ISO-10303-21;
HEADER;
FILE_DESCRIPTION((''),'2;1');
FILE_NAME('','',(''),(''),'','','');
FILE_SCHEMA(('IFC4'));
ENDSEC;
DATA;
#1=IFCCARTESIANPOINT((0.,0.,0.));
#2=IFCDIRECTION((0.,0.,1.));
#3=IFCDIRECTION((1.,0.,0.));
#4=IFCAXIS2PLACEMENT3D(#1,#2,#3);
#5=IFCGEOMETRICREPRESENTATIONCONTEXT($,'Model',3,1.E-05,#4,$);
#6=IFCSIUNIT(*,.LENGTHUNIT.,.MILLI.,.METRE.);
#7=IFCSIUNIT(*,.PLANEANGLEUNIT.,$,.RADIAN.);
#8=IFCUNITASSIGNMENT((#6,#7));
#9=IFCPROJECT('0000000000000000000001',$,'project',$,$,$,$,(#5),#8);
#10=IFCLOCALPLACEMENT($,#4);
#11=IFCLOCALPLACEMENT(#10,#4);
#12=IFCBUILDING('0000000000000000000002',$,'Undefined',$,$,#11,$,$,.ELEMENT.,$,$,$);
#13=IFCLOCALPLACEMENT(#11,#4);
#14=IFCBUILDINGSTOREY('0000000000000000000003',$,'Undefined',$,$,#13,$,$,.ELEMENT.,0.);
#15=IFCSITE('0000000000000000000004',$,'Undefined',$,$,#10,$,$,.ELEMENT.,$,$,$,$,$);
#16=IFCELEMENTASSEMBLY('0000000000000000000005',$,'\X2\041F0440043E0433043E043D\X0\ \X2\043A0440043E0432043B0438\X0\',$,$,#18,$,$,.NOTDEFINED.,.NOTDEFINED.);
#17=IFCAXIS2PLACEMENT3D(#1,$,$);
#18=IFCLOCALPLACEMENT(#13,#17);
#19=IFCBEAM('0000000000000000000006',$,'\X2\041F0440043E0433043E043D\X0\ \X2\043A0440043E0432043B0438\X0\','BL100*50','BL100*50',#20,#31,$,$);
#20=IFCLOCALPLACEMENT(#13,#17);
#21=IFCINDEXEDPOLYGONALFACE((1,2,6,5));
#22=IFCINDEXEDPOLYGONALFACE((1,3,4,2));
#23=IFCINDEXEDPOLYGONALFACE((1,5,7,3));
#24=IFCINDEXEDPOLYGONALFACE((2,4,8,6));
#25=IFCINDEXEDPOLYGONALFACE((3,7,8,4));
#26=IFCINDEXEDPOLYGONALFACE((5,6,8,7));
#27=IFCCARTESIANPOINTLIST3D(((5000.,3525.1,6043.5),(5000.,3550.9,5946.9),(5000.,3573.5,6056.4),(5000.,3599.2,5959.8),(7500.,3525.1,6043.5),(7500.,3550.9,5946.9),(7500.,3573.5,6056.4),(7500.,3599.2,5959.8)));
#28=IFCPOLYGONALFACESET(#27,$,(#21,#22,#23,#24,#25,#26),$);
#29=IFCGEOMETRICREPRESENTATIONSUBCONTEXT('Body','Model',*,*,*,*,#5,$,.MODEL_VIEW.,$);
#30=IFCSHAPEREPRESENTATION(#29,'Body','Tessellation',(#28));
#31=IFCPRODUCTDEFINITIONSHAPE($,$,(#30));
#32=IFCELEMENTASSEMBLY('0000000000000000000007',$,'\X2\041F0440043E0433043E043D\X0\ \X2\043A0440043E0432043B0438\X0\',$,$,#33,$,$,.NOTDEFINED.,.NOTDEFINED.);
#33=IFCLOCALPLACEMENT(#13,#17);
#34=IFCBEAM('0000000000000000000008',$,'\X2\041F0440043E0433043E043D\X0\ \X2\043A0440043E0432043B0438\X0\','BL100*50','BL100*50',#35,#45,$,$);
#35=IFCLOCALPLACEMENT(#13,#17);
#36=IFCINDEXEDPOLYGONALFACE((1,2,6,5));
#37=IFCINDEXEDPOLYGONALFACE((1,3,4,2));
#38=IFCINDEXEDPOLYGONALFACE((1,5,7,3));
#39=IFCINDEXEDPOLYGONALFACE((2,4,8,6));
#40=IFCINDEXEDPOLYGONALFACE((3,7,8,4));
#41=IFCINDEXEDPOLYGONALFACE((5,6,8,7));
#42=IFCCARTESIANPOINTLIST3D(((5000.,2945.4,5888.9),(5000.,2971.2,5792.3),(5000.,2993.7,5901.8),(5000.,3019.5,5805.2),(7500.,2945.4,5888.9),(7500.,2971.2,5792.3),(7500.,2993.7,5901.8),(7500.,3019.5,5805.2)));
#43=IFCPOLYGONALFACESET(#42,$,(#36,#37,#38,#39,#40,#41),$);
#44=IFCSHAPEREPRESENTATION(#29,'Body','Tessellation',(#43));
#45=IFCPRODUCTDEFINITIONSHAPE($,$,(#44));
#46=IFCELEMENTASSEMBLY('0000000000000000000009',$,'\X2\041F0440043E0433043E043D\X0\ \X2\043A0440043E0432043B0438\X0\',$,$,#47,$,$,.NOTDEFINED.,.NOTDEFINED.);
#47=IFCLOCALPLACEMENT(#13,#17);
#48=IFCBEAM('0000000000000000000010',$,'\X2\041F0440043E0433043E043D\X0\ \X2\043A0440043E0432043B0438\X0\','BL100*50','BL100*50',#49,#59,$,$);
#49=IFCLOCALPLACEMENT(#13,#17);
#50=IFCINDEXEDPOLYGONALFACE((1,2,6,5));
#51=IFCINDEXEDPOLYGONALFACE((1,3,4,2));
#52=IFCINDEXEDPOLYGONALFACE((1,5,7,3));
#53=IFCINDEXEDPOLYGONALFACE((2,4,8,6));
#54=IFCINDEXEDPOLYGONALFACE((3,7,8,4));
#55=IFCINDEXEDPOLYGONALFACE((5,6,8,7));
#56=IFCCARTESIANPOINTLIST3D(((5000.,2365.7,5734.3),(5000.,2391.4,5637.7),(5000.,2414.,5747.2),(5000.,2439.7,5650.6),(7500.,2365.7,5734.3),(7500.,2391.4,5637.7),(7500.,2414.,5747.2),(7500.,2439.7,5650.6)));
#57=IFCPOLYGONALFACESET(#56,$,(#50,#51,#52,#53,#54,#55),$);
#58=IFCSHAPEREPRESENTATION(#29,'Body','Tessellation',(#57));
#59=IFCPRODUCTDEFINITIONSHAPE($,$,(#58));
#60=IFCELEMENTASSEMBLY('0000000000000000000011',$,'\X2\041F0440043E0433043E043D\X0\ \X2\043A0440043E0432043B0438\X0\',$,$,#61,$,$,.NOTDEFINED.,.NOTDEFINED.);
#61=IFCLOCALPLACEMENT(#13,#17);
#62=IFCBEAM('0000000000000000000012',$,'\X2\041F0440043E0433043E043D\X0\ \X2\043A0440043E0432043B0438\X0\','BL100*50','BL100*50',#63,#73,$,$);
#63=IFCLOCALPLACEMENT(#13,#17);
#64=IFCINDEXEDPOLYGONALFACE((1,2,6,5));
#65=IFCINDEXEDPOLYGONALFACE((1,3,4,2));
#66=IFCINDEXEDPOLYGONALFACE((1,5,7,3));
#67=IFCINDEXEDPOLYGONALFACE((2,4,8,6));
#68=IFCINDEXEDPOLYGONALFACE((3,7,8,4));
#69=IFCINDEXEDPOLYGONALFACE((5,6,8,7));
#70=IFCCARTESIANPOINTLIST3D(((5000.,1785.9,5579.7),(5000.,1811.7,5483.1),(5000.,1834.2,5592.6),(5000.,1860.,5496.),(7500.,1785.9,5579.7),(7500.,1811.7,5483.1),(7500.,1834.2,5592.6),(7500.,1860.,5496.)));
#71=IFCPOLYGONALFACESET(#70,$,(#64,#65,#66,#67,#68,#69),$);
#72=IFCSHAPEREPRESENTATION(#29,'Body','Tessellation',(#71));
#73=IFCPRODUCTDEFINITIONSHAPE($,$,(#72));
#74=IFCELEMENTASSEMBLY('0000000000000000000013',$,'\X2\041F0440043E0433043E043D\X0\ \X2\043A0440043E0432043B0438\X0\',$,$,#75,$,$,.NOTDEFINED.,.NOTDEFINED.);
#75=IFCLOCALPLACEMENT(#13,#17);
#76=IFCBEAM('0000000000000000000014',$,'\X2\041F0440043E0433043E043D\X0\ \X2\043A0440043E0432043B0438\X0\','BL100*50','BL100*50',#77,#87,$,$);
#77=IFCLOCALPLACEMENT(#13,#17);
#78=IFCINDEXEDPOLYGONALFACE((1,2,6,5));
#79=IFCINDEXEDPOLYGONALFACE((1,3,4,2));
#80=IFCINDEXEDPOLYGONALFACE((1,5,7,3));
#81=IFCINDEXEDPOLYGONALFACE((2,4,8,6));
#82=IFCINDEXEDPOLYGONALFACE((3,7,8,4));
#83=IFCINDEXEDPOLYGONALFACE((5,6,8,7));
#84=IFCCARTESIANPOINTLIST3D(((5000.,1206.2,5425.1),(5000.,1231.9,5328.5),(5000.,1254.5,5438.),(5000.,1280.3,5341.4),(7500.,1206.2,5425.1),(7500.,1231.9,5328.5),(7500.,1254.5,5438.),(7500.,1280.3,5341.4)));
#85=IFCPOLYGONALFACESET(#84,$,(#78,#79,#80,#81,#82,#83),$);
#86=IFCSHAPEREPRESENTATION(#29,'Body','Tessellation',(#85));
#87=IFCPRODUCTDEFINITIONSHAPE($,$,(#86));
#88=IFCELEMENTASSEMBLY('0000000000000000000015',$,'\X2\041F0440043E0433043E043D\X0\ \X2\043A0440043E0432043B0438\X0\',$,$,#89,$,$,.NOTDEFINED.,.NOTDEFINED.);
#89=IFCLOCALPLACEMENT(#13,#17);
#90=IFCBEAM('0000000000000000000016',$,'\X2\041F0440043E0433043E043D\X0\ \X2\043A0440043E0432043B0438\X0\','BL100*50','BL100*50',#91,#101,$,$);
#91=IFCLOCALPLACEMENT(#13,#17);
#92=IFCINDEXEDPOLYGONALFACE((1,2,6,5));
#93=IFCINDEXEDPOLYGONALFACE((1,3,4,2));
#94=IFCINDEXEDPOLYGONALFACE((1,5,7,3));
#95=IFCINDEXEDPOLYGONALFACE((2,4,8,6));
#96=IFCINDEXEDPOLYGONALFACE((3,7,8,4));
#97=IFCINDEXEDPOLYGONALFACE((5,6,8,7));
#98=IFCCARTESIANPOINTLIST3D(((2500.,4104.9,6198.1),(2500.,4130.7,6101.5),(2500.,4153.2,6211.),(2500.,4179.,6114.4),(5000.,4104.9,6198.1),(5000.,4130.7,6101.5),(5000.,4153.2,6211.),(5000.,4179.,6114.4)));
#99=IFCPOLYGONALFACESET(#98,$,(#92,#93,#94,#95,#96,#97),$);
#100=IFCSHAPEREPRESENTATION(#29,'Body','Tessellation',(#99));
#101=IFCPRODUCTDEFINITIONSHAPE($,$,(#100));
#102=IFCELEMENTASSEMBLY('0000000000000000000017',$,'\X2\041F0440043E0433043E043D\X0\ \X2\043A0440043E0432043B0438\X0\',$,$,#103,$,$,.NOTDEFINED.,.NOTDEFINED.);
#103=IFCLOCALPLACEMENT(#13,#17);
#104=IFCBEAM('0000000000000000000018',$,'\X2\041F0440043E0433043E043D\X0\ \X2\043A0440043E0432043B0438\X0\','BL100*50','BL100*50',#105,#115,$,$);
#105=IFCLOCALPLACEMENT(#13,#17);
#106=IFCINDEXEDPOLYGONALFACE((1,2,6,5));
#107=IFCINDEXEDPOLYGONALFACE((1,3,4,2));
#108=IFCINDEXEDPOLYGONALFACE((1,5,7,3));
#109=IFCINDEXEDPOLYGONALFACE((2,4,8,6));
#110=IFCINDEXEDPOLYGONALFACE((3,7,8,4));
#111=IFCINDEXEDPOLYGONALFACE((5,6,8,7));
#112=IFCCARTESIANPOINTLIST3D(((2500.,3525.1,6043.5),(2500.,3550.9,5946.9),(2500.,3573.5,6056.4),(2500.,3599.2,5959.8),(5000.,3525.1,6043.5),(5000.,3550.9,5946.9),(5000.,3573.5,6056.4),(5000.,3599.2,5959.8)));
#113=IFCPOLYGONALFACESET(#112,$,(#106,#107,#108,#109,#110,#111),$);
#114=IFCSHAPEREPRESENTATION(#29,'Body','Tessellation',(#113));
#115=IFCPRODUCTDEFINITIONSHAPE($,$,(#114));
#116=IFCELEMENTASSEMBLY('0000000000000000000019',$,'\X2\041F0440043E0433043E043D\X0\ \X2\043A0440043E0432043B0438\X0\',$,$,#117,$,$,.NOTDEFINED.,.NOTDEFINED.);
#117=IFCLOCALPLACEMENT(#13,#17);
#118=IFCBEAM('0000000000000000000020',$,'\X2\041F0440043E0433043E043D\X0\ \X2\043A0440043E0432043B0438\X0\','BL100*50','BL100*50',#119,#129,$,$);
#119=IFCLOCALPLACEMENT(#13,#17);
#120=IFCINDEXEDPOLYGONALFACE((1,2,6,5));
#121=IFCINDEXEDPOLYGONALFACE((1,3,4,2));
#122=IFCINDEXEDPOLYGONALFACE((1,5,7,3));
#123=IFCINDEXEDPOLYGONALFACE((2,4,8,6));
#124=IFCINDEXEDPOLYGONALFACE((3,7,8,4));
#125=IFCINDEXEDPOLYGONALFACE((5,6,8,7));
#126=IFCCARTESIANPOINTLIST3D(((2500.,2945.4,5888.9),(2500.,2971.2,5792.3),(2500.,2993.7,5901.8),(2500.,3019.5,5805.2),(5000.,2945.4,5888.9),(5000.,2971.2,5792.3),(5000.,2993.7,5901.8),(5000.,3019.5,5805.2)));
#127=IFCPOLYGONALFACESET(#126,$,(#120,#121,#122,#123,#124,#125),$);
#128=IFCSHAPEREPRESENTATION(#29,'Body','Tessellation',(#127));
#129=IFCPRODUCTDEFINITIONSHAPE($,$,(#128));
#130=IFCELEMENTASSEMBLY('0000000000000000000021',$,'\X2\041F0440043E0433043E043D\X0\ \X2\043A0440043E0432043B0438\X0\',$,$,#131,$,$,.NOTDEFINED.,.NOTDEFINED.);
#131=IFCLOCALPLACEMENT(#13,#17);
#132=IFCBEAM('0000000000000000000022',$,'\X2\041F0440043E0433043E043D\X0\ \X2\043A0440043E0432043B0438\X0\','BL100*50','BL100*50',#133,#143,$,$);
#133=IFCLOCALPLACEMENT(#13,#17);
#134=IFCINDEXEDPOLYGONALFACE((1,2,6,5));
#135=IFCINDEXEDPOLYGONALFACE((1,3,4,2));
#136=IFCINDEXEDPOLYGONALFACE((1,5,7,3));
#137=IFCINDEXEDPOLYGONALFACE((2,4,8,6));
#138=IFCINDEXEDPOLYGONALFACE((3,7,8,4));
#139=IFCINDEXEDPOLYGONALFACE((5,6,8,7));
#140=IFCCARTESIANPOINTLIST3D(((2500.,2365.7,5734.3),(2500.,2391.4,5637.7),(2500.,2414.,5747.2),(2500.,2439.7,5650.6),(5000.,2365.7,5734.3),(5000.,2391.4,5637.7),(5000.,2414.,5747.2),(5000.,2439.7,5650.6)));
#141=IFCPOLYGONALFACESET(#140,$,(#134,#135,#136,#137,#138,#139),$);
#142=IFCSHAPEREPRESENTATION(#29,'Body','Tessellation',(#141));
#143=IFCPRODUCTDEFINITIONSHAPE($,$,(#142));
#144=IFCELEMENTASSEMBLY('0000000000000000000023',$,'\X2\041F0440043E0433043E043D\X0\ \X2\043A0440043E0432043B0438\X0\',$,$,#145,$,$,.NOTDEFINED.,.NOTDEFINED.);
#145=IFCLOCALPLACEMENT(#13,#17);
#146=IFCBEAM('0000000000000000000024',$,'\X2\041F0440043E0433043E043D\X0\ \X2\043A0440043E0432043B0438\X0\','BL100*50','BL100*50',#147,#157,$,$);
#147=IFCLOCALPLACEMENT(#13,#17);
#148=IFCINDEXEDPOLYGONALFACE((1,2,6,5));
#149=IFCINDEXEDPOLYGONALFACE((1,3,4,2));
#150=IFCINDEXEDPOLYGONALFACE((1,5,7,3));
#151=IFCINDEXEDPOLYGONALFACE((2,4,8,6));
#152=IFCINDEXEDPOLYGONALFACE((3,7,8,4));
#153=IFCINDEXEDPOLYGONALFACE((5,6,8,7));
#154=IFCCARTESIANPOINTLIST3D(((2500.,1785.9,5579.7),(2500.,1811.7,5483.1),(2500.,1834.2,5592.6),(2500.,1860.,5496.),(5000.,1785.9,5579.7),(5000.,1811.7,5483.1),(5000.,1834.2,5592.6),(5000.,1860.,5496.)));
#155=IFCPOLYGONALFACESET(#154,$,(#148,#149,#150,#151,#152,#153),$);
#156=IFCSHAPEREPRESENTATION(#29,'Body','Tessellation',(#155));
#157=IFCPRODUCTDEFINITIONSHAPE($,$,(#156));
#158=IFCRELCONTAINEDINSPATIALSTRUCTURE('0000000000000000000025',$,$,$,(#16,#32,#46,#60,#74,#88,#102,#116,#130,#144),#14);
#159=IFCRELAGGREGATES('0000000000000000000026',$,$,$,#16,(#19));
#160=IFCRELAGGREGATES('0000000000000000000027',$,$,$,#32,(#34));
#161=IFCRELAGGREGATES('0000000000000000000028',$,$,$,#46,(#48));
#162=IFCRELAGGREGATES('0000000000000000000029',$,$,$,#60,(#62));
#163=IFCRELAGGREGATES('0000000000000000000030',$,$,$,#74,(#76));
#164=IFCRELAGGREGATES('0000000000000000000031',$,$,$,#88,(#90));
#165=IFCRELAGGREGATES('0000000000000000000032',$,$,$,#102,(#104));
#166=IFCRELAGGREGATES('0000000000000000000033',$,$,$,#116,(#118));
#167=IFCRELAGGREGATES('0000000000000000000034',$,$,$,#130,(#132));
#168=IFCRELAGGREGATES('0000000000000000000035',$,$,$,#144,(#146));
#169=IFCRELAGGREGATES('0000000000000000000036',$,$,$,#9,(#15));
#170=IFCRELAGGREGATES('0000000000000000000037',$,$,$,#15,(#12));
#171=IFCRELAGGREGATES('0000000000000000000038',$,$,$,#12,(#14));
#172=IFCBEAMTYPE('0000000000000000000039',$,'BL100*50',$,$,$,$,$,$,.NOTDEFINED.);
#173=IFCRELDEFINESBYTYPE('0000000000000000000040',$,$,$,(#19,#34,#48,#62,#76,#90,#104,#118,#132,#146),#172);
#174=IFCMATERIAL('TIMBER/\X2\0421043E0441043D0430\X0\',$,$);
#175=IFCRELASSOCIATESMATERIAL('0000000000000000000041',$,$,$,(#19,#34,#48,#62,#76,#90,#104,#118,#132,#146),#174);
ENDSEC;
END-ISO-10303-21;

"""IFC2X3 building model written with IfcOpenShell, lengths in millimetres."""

from ifc_helpers import new_model, si_unit, frame, origin_with_axes, origin_2d_with_axis, place, context, subcontext, project, spatial, rectangle, extrude, material, type_object, element, aggregate, save


model = new_model("IFC2X3")

# Units and contexts
model_context = context("Model", 3, precision=1e-05, world=origin_with_axes())
body_context = subcontext(model_context, "Body", "Model", "MODEL_VIEW")
ifc_project = project(units=[si_unit("LENGTHUNIT", "METRE", prefix="MILLI"), si_unit("PLANEANGLEUNIT", "RADIAN")], contexts=[model_context])

# Site, building, storey
site_placement = place(None, origin_with_axes())
site = spatial("IfcSite", under=ifc_project, at=site_placement, Name="Undefined", CompositionType="ELEMENT")
building_placement = place(site_placement, origin_with_axes())
building = spatial("IfcBuilding", under=site, at=building_placement, Name="Undefined", CompositionType="ELEMENT")
storey_placement = place(building_placement, origin_with_axes())
storey = spatial("IfcBuildingStorey", under=building, at=storey_placement, Name="Undefined", CompositionType="ELEMENT", Elevation=0.0)

# Element assemblies, beams
assembly_1_placement = place(storey_placement, origin_with_axes())
assembly_1 = element("IfcElementAssembly", 1, at=assembly_1_placement, inside=storey, Name="Прогон кровли", AssemblyPlace="NOTDEFINED", PredefinedType="NOTDEFINED")
ifc_material_1 = material(Name="TIMBER/Сосна")
beam_type_1 = type_object("IfcBeamType", Name="BL100*50", PredefinedType="NOTDEFINED")
beam_1_placement = place(assembly_1_placement, frame((5000.0, 3562.2, 6001.7), z_axis=(0.0, 0.257663, -0.966235), x_axis=(1.0, 0.0, 0.0)))
beam_1 = element("IfcBeam", 2, at=beam_1_placement, type_object=beam_type_1, material=ifc_material_1, Name="Прогон кровли", Description="BL100*50", ObjectType="BL100*50", context=body_context, shape_type="SweptSolid", body=[
    extrude(rectangle(XDim=50.0, YDim=100.0, at=origin_2d_with_axis()), frame((2500.0, 0.0, 0.0), z_axis=(-1.0, 0.0, 0.0), x_axis=(0.0, -1.0, 0.0)), (0.0, 0.0, 1.0), 2500.0),
])
aggregate(assembly_1, [beam_1])
assembly_2_placement = place(storey_placement, origin_with_axes())
assembly_2 = element("IfcElementAssembly", 3, at=assembly_2_placement, inside=storey, Name="Прогон кровли", AssemblyPlace="NOTDEFINED", PredefinedType="NOTDEFINED")
beam_2_placement = place(assembly_2_placement, frame((5000.0, 2982.4, 5847.1), z_axis=(0.0, 0.257663, -0.966235), x_axis=(1.0, 0.0, 0.0)))
beam_2 = element("IfcBeam", 4, at=beam_2_placement, type_object=beam_type_1, material=ifc_material_1, Name="Прогон кровли", Description="BL100*50", ObjectType="BL100*50", context=body_context, shape_type="SweptSolid", body=[
    extrude(rectangle(XDim=50.0, YDim=100.0, at=origin_2d_with_axis()), frame((2500.0, 0.0, 0.0), z_axis=(-1.0, 0.0, 0.0), x_axis=(0.0, -1.0, 0.0)), (0.0, 0.0, 1.0), 2500.0),
])
aggregate(assembly_2, [beam_2])
assembly_3_placement = place(storey_placement, origin_with_axes())
assembly_3 = element("IfcElementAssembly", 5, at=assembly_3_placement, inside=storey, Name="Прогон кровли", AssemblyPlace="NOTDEFINED", PredefinedType="NOTDEFINED")
beam_3_placement = place(assembly_3_placement, frame((5000.0, 2402.7, 5692.5), z_axis=(0.0, 0.257663, -0.966235), x_axis=(1.0, 0.0, 0.0)))
beam_3 = element("IfcBeam", 6, at=beam_3_placement, type_object=beam_type_1, material=ifc_material_1, Name="Прогон кровли", Description="BL100*50", ObjectType="BL100*50", context=body_context, shape_type="SweptSolid", body=[
    extrude(rectangle(XDim=50.0, YDim=100.0, at=origin_2d_with_axis()), frame((2500.0, 0.0, 0.0), z_axis=(-1.0, 0.0, 0.0), x_axis=(0.0, -1.0, 0.0)), (0.0, 0.0, 1.0), 2500.0),
])
aggregate(assembly_3, [beam_3])
assembly_4_placement = place(storey_placement, origin_with_axes())
assembly_4 = element("IfcElementAssembly", 7, at=assembly_4_placement, inside=storey, Name="Прогон кровли", AssemblyPlace="NOTDEFINED", PredefinedType="NOTDEFINED")
beam_4_placement = place(assembly_4_placement, frame((5000.0, 1823.0, 5537.9), z_axis=(0.0, 0.257663, -0.966235), x_axis=(1.0, 0.0, 0.0)))
beam_4 = element("IfcBeam", 8, at=beam_4_placement, type_object=beam_type_1, material=ifc_material_1, Name="Прогон кровли", Description="BL100*50", ObjectType="BL100*50", context=body_context, shape_type="SweptSolid", body=[
    extrude(rectangle(XDim=50.0, YDim=100.0, at=origin_2d_with_axis()), frame((2500.0, 0.0, 0.0), z_axis=(-1.0, 0.0, 0.0), x_axis=(0.0, -1.0, 0.0)), (0.0, 0.0, 1.0), 2500.0),
])
aggregate(assembly_4, [beam_4])
assembly_5_placement = place(storey_placement, origin_with_axes())
assembly_5 = element("IfcElementAssembly", 9, at=assembly_5_placement, inside=storey, Name="Прогон кровли", AssemblyPlace="NOTDEFINED", PredefinedType="NOTDEFINED")
beam_5_placement = place(assembly_5_placement, frame((5000.0, 1243.2, 5383.3), z_axis=(0.0, 0.257663, -0.966235), x_axis=(1.0, 0.0, 0.0)))
beam_5 = element("IfcBeam", 10, at=beam_5_placement, type_object=beam_type_1, material=ifc_material_1, Name="Прогон кровли", Description="BL100*50", ObjectType="BL100*50", context=body_context, shape_type="SweptSolid", body=[
    extrude(rectangle(XDim=50.0, YDim=100.0, at=origin_2d_with_axis()), frame((2500.0, 0.0, 0.0), z_axis=(-1.0, 0.0, 0.0), x_axis=(0.0, -1.0, 0.0)), (0.0, 0.0, 1.0), 2500.0),
])
aggregate(assembly_5, [beam_5])
assembly_6_placement = place(storey_placement, origin_with_axes())
assembly_6 = element("IfcElementAssembly", 11, at=assembly_6_placement, inside=storey, Name="Прогон кровли", AssemblyPlace="NOTDEFINED", PredefinedType="NOTDEFINED")
beam_6_placement = place(assembly_6_placement, frame((2500.0, 4141.9, 6156.3), z_axis=(0.0, 0.257663, -0.966235), x_axis=(1.0, 0.0, 0.0)))
beam_6 = element("IfcBeam", 12, at=beam_6_placement, type_object=beam_type_1, material=ifc_material_1, Name="Прогон кровли", Description="BL100*50", ObjectType="BL100*50", context=body_context, shape_type="SweptSolid", body=[
    extrude(rectangle(XDim=50.0, YDim=100.0, at=origin_2d_with_axis()), frame((2500.0, 0.0, 0.0), z_axis=(-1.0, 0.0, 0.0), x_axis=(0.0, -1.0, 0.0)), (0.0, 0.0, 1.0), 2500.0),
])
aggregate(assembly_6, [beam_6])
assembly_7_placement = place(storey_placement, origin_with_axes())
assembly_7 = element("IfcElementAssembly", 13, at=assembly_7_placement, inside=storey, Name="Прогон кровли", AssemblyPlace="NOTDEFINED", PredefinedType="NOTDEFINED")
beam_7_placement = place(assembly_7_placement, frame((2500.0, 3562.2, 6001.7), z_axis=(0.0, 0.257663, -0.966235), x_axis=(1.0, 0.0, 0.0)))
beam_7 = element("IfcBeam", 14, at=beam_7_placement, type_object=beam_type_1, material=ifc_material_1, Name="Прогон кровли", Description="BL100*50", ObjectType="BL100*50", context=body_context, shape_type="SweptSolid", body=[
    extrude(rectangle(XDim=50.0, YDim=100.0, at=origin_2d_with_axis()), frame((2500.0, 0.0, 0.0), z_axis=(-1.0, 0.0, 0.0), x_axis=(0.0, -1.0, 0.0)), (0.0, 0.0, 1.0), 2500.0),
])
aggregate(assembly_7, [beam_7])
assembly_8_placement = place(storey_placement, origin_with_axes())
assembly_8 = element("IfcElementAssembly", 15, at=assembly_8_placement, inside=storey, Name="Прогон кровли", AssemblyPlace="NOTDEFINED", PredefinedType="NOTDEFINED")
beam_8_placement = place(assembly_8_placement, frame((2500.0, 2982.4, 5847.1), z_axis=(0.0, 0.257663, -0.966235), x_axis=(1.0, 0.0, 0.0)))
beam_8 = element("IfcBeam", 16, at=beam_8_placement, type_object=beam_type_1, material=ifc_material_1, Name="Прогон кровли", Description="BL100*50", ObjectType="BL100*50", context=body_context, shape_type="SweptSolid", body=[
    extrude(rectangle(XDim=50.0, YDim=100.0, at=origin_2d_with_axis()), frame((2500.0, 0.0, 0.0), z_axis=(-1.0, 0.0, 0.0), x_axis=(0.0, -1.0, 0.0)), (0.0, 0.0, 1.0), 2500.0),
])
aggregate(assembly_8, [beam_8])
assembly_9_placement = place(storey_placement, origin_with_axes())
assembly_9 = element("IfcElementAssembly", 17, at=assembly_9_placement, inside=storey, Name="Прогон кровли", AssemblyPlace="NOTDEFINED", PredefinedType="NOTDEFINED")
beam_9_placement = place(assembly_9_placement, frame((2500.0, 2402.7, 5692.5), z_axis=(0.0, 0.257663, -0.966235), x_axis=(1.0, 0.0, 0.0)))
beam_9 = element("IfcBeam", 18, at=beam_9_placement, type_object=beam_type_1, material=ifc_material_1, Name="Прогон кровли", Description="BL100*50", ObjectType="BL100*50", context=body_context, shape_type="SweptSolid", body=[
    extrude(rectangle(XDim=50.0, YDim=100.0, at=origin_2d_with_axis()), frame((2500.0, 0.0, 0.0), z_axis=(-1.0, 0.0, 0.0), x_axis=(0.0, -1.0, 0.0)), (0.0, 0.0, 1.0), 2500.0),
])
aggregate(assembly_9, [beam_9])
assembly_10_placement = place(storey_placement, origin_with_axes())
assembly_10 = element("IfcElementAssembly", 19, at=assembly_10_placement, inside=storey, Name="Прогон кровли", AssemblyPlace="NOTDEFINED", PredefinedType="NOTDEFINED")
beam_10_placement = place(assembly_10_placement, frame((2500.0, 1823.0, 5537.9), z_axis=(0.0, 0.257663, -0.966235), x_axis=(1.0, 0.0, 0.0)))
beam_10 = element("IfcBeam", 20, at=beam_10_placement, type_object=beam_type_1, material=ifc_material_1, Name="Прогон кровли", Description="BL100*50", ObjectType="BL100*50", context=body_context, shape_type="SweptSolid", body=[
    extrude(rectangle(XDim=50.0, YDim=100.0, at=origin_2d_with_axis()), frame((2500.0, 0.0, 0.0), z_axis=(-1.0, 0.0, 0.0), x_axis=(0.0, -1.0, 0.0)), (0.0, 0.0, 1.0), 2500.0),
])
aggregate(assembly_10, [beam_10])

save(model, "model.ifc")
